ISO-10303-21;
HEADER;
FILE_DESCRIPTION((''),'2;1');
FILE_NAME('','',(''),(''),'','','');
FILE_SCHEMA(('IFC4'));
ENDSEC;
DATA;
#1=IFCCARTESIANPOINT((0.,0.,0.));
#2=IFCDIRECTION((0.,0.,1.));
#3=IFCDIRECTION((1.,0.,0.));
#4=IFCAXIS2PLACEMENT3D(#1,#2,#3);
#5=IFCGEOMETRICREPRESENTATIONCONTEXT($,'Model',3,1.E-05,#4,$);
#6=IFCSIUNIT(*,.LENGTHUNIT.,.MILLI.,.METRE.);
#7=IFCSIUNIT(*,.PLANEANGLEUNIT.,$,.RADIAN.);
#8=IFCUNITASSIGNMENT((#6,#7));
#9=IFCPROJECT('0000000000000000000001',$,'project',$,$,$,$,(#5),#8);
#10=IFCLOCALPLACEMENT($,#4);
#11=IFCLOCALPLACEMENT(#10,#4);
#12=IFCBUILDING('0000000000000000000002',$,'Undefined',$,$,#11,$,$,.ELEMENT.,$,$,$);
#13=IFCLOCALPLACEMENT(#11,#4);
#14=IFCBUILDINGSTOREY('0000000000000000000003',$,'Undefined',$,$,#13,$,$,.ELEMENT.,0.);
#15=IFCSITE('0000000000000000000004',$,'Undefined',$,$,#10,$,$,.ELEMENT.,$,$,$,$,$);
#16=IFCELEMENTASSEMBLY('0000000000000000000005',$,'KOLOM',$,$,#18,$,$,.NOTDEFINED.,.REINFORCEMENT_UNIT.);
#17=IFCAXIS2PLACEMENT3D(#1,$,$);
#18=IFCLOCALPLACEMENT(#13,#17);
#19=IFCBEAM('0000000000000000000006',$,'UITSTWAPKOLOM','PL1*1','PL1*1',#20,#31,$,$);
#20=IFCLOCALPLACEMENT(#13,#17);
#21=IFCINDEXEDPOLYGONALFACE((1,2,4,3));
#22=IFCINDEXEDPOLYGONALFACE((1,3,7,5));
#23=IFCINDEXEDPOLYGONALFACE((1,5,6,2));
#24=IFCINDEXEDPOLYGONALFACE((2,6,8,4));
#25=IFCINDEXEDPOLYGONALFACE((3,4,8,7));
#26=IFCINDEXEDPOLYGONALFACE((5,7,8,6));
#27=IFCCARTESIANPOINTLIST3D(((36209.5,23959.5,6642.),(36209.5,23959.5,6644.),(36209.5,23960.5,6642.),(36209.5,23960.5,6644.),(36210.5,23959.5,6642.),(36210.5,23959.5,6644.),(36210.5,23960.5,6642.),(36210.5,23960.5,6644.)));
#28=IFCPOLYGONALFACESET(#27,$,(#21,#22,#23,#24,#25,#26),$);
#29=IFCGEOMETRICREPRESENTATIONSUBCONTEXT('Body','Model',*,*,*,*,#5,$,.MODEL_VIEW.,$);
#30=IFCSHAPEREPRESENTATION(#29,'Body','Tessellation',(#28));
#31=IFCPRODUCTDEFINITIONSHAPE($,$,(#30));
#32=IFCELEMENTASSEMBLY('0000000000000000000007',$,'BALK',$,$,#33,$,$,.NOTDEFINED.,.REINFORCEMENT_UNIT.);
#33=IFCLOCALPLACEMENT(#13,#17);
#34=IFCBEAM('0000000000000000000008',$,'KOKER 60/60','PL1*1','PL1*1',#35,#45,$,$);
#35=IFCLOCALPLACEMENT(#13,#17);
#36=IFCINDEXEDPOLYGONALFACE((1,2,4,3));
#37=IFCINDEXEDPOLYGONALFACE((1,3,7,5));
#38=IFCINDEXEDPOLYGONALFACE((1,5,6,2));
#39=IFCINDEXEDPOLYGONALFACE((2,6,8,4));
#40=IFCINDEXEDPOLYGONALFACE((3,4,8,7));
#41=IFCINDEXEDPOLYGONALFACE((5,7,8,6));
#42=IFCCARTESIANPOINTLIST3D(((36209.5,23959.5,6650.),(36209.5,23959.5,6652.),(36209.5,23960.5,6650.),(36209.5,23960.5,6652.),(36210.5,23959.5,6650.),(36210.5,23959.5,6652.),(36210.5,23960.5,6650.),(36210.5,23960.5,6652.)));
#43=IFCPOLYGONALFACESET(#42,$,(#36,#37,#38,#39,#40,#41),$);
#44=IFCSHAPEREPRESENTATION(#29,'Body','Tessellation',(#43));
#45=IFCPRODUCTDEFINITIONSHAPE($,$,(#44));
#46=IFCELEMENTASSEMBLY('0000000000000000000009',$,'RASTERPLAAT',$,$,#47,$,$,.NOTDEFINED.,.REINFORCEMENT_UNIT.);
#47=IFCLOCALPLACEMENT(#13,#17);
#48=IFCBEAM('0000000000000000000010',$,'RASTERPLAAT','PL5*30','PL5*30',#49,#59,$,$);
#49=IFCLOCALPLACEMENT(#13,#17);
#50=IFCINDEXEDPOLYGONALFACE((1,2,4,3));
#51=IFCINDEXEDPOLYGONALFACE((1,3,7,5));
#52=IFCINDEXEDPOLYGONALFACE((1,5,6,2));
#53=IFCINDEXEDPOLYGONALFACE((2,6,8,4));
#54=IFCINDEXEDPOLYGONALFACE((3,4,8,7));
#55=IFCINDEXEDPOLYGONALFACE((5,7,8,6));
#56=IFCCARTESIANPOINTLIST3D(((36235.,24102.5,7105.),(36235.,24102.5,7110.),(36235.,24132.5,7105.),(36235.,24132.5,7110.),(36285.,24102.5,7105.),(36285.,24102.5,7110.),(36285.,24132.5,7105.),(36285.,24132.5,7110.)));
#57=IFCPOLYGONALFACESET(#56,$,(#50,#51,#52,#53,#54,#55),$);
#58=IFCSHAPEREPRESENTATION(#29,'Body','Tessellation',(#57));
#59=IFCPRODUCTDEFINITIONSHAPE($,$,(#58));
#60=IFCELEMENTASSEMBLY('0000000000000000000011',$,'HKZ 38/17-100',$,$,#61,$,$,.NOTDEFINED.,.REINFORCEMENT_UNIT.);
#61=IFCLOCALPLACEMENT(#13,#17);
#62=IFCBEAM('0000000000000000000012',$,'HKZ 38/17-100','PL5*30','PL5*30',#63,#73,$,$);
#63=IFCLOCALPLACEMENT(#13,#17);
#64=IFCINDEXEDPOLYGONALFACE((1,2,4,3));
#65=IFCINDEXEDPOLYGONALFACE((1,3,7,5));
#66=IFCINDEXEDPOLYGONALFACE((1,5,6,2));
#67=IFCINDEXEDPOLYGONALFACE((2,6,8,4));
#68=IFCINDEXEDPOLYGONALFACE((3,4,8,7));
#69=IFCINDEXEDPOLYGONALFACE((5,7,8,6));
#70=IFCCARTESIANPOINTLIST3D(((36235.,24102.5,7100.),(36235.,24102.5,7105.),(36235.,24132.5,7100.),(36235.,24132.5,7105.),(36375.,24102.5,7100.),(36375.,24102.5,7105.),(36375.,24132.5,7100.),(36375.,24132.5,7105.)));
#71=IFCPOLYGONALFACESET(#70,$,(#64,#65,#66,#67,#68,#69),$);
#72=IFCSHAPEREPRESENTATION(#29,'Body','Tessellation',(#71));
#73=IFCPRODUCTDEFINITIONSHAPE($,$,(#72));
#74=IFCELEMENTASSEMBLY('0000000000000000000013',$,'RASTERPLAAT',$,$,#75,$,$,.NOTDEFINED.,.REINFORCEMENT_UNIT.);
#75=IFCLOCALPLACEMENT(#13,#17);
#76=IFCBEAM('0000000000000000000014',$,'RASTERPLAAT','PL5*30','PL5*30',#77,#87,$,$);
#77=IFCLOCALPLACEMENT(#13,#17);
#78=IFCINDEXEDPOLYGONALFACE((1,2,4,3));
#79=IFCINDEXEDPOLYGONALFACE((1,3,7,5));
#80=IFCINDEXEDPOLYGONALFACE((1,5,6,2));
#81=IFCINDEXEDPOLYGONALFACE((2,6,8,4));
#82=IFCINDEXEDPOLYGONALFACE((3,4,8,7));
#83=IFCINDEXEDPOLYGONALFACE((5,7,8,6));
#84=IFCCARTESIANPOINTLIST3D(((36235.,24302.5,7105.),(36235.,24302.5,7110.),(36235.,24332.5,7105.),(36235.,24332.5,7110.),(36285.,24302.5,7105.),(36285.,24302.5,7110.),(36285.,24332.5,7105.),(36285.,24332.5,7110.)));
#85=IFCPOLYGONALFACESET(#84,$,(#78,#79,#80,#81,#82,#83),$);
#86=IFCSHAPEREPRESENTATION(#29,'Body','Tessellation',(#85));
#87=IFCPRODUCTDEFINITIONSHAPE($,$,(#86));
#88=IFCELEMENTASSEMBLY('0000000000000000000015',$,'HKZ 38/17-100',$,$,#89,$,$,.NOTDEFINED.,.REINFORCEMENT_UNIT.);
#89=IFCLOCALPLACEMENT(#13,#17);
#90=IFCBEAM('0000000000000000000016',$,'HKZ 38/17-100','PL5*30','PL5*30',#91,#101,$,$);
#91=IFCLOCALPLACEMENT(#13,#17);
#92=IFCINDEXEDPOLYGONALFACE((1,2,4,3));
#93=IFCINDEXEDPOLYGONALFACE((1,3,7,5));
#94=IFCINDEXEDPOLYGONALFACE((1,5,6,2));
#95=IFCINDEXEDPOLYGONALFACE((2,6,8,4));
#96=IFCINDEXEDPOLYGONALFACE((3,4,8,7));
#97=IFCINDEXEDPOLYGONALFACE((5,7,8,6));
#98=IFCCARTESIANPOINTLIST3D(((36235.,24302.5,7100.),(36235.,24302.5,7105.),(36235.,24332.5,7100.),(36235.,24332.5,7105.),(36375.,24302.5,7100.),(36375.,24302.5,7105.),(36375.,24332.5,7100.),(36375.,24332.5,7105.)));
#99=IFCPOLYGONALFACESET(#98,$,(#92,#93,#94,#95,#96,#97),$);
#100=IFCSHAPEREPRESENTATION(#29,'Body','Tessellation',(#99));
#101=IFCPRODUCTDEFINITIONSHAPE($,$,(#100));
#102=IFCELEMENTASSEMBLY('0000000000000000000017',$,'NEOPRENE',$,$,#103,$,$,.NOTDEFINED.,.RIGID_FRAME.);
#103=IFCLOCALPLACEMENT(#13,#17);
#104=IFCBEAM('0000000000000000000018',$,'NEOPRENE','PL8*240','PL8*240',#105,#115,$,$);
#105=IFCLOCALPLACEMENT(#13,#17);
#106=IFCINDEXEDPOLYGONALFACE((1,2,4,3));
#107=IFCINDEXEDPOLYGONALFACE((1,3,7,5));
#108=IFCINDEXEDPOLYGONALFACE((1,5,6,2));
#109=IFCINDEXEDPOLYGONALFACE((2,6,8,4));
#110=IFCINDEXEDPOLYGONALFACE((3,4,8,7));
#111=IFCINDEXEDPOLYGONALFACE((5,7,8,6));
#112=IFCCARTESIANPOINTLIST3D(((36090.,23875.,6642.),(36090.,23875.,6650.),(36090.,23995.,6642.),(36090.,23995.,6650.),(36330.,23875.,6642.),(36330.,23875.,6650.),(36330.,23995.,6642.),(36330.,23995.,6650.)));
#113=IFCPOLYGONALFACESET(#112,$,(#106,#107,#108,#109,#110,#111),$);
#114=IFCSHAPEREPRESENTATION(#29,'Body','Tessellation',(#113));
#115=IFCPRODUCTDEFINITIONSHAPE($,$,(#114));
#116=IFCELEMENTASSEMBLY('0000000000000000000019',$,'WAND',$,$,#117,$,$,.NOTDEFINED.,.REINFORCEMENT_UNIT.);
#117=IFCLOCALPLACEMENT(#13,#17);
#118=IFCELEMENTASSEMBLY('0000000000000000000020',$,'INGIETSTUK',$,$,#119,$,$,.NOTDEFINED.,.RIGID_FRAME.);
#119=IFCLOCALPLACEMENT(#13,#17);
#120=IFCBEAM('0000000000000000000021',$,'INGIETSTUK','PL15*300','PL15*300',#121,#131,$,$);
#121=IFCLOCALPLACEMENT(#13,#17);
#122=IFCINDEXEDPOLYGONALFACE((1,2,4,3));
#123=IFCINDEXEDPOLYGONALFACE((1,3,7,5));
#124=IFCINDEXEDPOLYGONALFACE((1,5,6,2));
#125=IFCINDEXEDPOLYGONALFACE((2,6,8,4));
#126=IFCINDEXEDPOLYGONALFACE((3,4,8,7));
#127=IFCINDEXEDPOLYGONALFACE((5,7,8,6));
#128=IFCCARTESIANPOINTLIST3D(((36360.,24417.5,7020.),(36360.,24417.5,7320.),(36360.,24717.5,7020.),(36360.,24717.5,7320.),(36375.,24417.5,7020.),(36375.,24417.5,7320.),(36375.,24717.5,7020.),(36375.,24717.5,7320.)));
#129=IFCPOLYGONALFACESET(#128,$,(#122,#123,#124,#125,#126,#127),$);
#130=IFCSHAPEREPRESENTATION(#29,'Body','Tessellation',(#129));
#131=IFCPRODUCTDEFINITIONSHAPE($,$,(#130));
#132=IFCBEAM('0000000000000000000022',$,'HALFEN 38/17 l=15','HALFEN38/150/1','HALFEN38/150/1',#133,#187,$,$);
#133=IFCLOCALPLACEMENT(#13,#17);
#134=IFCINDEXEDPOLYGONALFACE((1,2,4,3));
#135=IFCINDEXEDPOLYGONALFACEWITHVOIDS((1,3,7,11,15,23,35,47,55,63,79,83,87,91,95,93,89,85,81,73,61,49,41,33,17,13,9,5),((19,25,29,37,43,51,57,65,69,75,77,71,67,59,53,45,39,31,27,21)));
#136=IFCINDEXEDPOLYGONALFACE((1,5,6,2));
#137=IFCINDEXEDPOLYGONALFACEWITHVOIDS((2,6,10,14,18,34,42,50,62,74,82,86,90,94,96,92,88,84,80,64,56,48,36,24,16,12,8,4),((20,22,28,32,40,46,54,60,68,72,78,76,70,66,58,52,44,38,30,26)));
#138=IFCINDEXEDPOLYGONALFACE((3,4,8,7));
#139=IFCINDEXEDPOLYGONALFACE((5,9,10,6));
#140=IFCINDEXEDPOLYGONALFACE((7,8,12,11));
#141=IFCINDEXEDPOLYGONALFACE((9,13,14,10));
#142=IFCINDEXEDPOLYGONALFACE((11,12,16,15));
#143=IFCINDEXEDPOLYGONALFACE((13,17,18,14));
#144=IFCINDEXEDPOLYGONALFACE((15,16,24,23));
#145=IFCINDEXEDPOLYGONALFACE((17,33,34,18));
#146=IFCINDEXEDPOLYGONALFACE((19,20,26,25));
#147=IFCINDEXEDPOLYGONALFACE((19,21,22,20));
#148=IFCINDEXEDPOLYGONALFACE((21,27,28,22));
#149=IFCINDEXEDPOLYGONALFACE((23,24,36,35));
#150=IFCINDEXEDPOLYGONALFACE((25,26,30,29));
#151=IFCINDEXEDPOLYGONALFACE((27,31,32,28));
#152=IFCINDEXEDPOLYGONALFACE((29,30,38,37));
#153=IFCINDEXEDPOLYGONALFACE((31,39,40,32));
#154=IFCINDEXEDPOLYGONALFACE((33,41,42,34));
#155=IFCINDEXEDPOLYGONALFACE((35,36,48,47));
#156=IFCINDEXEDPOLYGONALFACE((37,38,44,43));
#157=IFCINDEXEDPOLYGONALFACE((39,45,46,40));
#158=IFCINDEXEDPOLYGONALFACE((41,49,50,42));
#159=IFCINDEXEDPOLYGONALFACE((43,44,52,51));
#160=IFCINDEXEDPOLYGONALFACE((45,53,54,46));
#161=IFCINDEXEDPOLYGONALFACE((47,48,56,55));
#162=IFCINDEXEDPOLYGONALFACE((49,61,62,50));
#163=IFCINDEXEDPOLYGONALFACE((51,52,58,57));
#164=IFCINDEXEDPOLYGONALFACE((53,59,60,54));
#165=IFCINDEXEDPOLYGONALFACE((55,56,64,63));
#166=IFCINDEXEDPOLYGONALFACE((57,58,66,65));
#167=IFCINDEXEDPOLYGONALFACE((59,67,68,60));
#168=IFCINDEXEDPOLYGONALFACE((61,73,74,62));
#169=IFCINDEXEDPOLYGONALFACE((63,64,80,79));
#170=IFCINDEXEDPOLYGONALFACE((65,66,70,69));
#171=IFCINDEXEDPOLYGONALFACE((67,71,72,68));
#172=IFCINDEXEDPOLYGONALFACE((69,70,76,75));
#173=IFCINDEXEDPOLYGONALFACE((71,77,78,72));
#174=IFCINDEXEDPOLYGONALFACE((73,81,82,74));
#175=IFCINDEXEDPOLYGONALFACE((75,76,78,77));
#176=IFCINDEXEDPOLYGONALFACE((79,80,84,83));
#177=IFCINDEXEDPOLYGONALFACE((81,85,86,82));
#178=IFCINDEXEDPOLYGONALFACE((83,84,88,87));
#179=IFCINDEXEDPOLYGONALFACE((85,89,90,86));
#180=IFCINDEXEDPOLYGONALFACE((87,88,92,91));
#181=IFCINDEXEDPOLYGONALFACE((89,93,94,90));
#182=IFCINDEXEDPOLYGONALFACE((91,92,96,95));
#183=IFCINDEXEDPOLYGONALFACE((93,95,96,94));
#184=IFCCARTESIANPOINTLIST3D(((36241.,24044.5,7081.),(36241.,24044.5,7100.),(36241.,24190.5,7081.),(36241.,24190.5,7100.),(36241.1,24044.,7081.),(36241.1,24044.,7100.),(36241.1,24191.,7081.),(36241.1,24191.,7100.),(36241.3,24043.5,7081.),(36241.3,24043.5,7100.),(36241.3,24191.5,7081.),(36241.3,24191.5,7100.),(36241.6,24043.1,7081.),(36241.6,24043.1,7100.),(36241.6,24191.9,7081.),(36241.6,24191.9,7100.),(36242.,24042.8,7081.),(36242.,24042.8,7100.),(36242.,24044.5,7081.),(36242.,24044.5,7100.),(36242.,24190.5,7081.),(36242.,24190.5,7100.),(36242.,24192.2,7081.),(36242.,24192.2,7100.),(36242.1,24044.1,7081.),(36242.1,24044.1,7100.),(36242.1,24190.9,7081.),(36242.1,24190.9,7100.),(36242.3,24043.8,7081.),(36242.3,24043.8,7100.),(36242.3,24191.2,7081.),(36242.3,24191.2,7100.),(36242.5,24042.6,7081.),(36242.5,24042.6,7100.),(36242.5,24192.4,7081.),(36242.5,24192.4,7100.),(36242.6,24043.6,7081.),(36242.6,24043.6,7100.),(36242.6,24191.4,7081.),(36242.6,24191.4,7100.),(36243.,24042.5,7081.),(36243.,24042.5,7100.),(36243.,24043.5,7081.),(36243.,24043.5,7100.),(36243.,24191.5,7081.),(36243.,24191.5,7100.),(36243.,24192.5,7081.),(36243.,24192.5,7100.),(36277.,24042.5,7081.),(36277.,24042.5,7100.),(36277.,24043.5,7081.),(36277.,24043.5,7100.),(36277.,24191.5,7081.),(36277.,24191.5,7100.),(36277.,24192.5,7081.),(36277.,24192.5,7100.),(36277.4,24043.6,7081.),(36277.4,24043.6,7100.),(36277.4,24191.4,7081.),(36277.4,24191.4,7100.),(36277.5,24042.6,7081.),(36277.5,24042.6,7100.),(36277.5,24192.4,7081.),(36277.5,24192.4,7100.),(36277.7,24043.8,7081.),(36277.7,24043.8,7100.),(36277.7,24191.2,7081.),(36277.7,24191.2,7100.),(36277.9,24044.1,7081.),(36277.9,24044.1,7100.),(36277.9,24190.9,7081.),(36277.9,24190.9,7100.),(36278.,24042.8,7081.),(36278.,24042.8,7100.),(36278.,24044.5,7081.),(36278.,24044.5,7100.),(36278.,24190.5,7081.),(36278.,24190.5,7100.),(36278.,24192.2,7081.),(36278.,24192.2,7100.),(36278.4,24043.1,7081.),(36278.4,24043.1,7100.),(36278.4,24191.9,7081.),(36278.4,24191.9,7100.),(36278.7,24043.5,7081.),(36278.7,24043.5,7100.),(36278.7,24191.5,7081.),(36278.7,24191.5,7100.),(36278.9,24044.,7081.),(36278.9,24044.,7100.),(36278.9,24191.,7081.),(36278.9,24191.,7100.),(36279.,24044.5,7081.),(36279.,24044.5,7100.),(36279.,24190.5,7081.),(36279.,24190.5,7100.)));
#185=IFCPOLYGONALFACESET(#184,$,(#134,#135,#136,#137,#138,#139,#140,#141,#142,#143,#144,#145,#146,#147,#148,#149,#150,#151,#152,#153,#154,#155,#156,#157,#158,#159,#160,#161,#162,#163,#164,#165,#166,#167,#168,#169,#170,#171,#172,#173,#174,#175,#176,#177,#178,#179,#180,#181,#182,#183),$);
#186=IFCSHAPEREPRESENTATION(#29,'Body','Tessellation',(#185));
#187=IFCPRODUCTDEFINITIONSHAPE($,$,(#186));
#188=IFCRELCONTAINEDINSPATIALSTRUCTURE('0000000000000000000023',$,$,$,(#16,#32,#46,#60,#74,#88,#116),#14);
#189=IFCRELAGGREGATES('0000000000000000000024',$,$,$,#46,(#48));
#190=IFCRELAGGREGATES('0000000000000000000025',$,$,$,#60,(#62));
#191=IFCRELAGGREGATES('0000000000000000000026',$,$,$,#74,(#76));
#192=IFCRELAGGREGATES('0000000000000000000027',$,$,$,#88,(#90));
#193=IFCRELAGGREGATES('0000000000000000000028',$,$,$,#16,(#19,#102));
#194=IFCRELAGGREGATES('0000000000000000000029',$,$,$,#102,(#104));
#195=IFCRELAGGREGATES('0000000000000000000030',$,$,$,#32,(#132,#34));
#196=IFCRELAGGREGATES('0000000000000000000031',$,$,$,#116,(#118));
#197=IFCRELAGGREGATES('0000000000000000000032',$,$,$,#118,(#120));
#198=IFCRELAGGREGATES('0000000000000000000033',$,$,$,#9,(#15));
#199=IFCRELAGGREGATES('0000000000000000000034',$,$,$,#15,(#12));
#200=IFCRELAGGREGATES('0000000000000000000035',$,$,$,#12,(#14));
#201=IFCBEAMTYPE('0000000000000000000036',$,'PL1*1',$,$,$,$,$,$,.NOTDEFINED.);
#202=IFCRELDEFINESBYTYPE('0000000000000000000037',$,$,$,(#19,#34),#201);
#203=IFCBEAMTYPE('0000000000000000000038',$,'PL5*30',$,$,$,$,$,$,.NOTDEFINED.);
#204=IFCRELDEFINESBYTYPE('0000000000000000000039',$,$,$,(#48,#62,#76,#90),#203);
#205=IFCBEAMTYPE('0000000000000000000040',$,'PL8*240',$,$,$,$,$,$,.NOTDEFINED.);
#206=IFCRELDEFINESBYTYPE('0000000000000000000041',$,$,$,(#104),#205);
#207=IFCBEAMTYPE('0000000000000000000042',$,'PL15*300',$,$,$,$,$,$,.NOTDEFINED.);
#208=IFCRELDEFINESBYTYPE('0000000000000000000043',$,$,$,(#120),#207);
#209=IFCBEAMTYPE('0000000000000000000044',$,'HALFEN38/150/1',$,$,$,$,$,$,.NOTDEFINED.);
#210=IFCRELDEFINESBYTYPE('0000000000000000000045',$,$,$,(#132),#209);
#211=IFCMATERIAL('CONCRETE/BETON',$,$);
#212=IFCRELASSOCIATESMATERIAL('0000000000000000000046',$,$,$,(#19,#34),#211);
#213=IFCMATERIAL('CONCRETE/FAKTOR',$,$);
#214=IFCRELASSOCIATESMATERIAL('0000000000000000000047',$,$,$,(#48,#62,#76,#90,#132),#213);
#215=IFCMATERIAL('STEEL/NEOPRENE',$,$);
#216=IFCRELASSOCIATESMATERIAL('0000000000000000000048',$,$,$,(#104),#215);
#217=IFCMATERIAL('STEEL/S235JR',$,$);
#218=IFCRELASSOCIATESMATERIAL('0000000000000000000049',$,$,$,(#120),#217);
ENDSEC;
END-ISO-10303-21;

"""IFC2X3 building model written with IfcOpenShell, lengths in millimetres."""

from ifc_helpers import new_model, si_unit, frame, frame_2d, origin_with_axes, place, context, subcontext, project, spatial, rectangle, hollow_rectangle, extrude, material, type_object, element, aggregate, save


model = new_model("IFC2X3")

# Units and contexts
model_context = context("Model", 3, precision=1e-05, world=origin_with_axes())
body_context = subcontext(model_context, "Body", "Model", "MODEL_VIEW")
ifc_project = project(units=[si_unit("LENGTHUNIT", "METRE", prefix="MILLI"), si_unit("PLANEANGLEUNIT", "RADIAN")], contexts=[model_context])

# Site, building, storey
site_placement = place(None, origin_with_axes())
site = spatial("IfcSite", under=ifc_project, at=site_placement, Name="Undefined", CompositionType="ELEMENT")
building_placement = place(site_placement, origin_with_axes())
building = spatial("IfcBuilding", under=site, at=building_placement, Name="Undefined", CompositionType="ELEMENT")
storey_placement = place(building_placement, origin_with_axes())
storey = spatial("IfcBuildingStorey", under=building, at=storey_placement, Name="Undefined", CompositionType="ELEMENT", Elevation=0.0)

# Element assemblies, beams
assembly_1_placement = place(storey_placement, origin_with_axes())
assembly_1 = element("IfcElementAssembly", 1, at=assembly_1_placement, inside=storey, Name="KOLOM", AssemblyPlace="NOTDEFINED", PredefinedType="REINFORCEMENT_UNIT")
ifc_material_1 = material(Name="CONCRETE/BETON")
beam_type_1 = type_object("IfcBeamType", Name="PL1*1", PredefinedType="NOTDEFINED")
beam_1_placement = place(assembly_1_placement, frame((36210.0, 23960.0, 6642.0), z_axis=(-1.0, 0.0, 0.0), x_axis=(0.0, 0.0, 1.0)))
beam_1 = element("IfcBeam", 2, at=beam_1_placement, type_object=beam_type_1, material=ifc_material_1, Name="UITSTWAPKOLOM", Description="PL1*1", ObjectType="PL1*1", context=body_context, shape_type="SweptSolid", body=[
    extrude(rectangle(XDim=1.0, YDim=1.0, at=frame_2d((0.0, 0.0), x_axis=(1.0, 0.0))), frame((2.0, 0.0, 0.0), z_axis=(-1.0, 0.0, 0.0), x_axis=(0.0, -1.0, 0.0)), (0.0, 0.0, 1.0), 2.0),
])
assembly_2_placement = place(storey_placement, origin_with_axes())
assembly_2 = element("IfcElementAssembly", 3, at=assembly_2_placement, inside=storey, Name="BALK", AssemblyPlace="NOTDEFINED", PredefinedType="REINFORCEMENT_UNIT")
beam_2_placement = place(assembly_2_placement, frame((36210.0, 23960.0, 6650.0), z_axis=(-1.0, 0.0, 0.0), x_axis=(0.0, 0.0, 1.0)))
beam_2 = element("IfcBeam", 4, at=beam_2_placement, type_object=beam_type_1, material=ifc_material_1, Name="KOKER 60/60", Description="PL1*1", ObjectType="PL1*1", context=body_context, shape_type="SweptSolid", body=[
    extrude(rectangle(XDim=1.0, YDim=1.0, at=frame_2d((0.0, 0.0), x_axis=(1.0, 0.0))), frame((2.0, 0.0, 0.0), z_axis=(-1.0, 0.0, 0.0), x_axis=(0.0, -1.0, 0.0)), (0.0, 0.0, 1.0), 2.0),
])
assembly_3_placement = place(storey_placement, origin_with_axes())
assembly_3 = element("IfcElementAssembly", 5, at=assembly_3_placement, inside=storey, Name="RASTERPLAAT", AssemblyPlace="NOTDEFINED", PredefinedType="REINFORCEMENT_UNIT")
ifc_material_2 = material(Name="CONCRETE/FAKTOR")
beam_type_2 = type_object("IfcBeamType", Name="PL5*30", PredefinedType="NOTDEFINED")
beam_3_placement = place(assembly_3_placement, frame((36235.0, 24117.5, 7107.5), z_axis=(0.0, -1.0, 0.0), x_axis=(1.0, 0.0, 0.0)))
beam_3 = element("IfcBeam", 6, at=beam_3_placement, type_object=beam_type_2, material=ifc_material_2, Name="RASTERPLAAT", Description="PL5*30", ObjectType="PL5*30", context=body_context, shape_type="SweptSolid", body=[
    extrude(rectangle(XDim=5.0, YDim=30.0, at=frame_2d((0.0, 0.0), x_axis=(1.0, 0.0))), frame((50.0, 0.0, 0.0), z_axis=(-1.0, 0.0, 0.0), x_axis=(0.0, -1.0, 0.0)), (0.0, 0.0, 1.0), 50.0),
])
aggregate(assembly_3, [beam_3])
assembly_4_placement = place(storey_placement, origin_with_axes())
assembly_4 = element("IfcElementAssembly", 7, at=assembly_4_placement, inside=storey, Name="HKZ 38/17-100", AssemblyPlace="NOTDEFINED", PredefinedType="REINFORCEMENT_UNIT")
beam_4_placement = place(assembly_4_placement, frame((36375.0, 24117.5, 7102.5), z_axis=(0.0, 1.0, 0.0), x_axis=(-1.0, 0.0, 0.0)))
beam_4 = element("IfcBeam", 8, at=beam_4_placement, type_object=beam_type_2, material=ifc_material_2, Name="HKZ 38/17-100", Description="PL5*30", ObjectType="PL5*30", context=body_context, shape_type="SweptSolid", body=[
    extrude(rectangle(XDim=5.0, YDim=30.0, at=frame_2d((0.0, 0.0), x_axis=(1.0, 0.0))), frame((140.0, 0.0, 0.0), z_axis=(-1.0, 0.0, 0.0), x_axis=(0.0, -1.0, 0.0)), (0.0, 0.0, 1.0), 140.0),
])
aggregate(assembly_4, [beam_4])
assembly_5_placement = place(storey_placement, origin_with_axes())
assembly_5 = element("IfcElementAssembly", 9, at=assembly_5_placement, inside=storey, Name="RASTERPLAAT", AssemblyPlace="NOTDEFINED", PredefinedType="REINFORCEMENT_UNIT")
beam_5_placement = place(assembly_5_placement, frame((36235.0, 24317.5, 7107.5), z_axis=(0.0, -1.0, 0.0), x_axis=(1.0, 0.0, 0.0)))
beam_5 = element("IfcBeam", 10, at=beam_5_placement, type_object=beam_type_2, material=ifc_material_2, Name="RASTERPLAAT", Description="PL5*30", ObjectType="PL5*30", context=body_context, shape_type="SweptSolid", body=[
    extrude(rectangle(XDim=5.0, YDim=30.0, at=frame_2d((0.0, 0.0), x_axis=(1.0, 0.0))), frame((50.0, 0.0, 0.0), z_axis=(-1.0, 0.0, 0.0), x_axis=(0.0, -1.0, 0.0)), (0.0, 0.0, 1.0), 50.0),
])
aggregate(assembly_5, [beam_5])
assembly_6_placement = place(storey_placement, origin_with_axes())
assembly_6 = element("IfcElementAssembly", 11, at=assembly_6_placement, inside=storey, Name="HKZ 38/17-100", AssemblyPlace="NOTDEFINED", PredefinedType="REINFORCEMENT_UNIT")
beam_6_placement = place(assembly_6_placement, frame((36375.0, 24317.5, 7102.5), z_axis=(0.0, 1.0, 0.0), x_axis=(-1.0, 0.0, 0.0)))
beam_6 = element("IfcBeam", 12, at=beam_6_placement, type_object=beam_type_2, material=ifc_material_2, Name="HKZ 38/17-100", Description="PL5*30", ObjectType="PL5*30", context=body_context, shape_type="SweptSolid", body=[
    extrude(rectangle(XDim=5.0, YDim=30.0, at=frame_2d((0.0, 0.0), x_axis=(1.0, 0.0))), frame((140.0, 0.0, 0.0), z_axis=(-1.0, 0.0, 0.0), x_axis=(0.0, -1.0, 0.0)), (0.0, 0.0, 1.0), 140.0),
])
aggregate(assembly_6, [beam_6])

# Element assembly
assembly_7_placement = place(assembly_1_placement, origin_with_axes())
assembly_7 = element("IfcElementAssembly", 13, at=assembly_7_placement, Name="NEOPRENE", AssemblyPlace="NOTDEFINED", PredefinedType="RIGID_FRAME")
aggregate(assembly_1, [beam_1, assembly_7])

# Beam
ifc_material_3 = material(Name="STEEL/NEOPRENE")
beam_type_3 = type_object("IfcBeamType", Name="PL8*240", PredefinedType="NOTDEFINED")
beam_7_placement = place(assembly_7_placement, frame((36210.0, 23875.0, 6646.0), z_axis=(-1.0, 0.0, 0.0), x_axis=(0.0, 1.0, 0.0)))
beam_7 = element("IfcBeam", 14, at=beam_7_placement, type_object=beam_type_3, material=ifc_material_3, Name="NEOPRENE", Description="PL8*240", ObjectType="PL8*240", context=body_context, shape_type="SweptSolid", body=[
    extrude(rectangle(XDim=8.0, YDim=240.0, at=frame_2d((0.0, 0.0), x_axis=(1.0, 0.0))), frame((120.0, 0.0, 0.0), z_axis=(-1.0, 0.0, 0.0), x_axis=(0.0, -1.0, 0.0)), (0.0, 0.0, 1.0), 120.0),
])
aggregate(assembly_7, [beam_7])

# Element assemblies, beam
assembly_8_placement = place(storey_placement, origin_with_axes())
assembly_8 = element("IfcElementAssembly", 15, at=assembly_8_placement, inside=storey, Name="WAND", AssemblyPlace="NOTDEFINED", PredefinedType="REINFORCEMENT_UNIT")
assembly_9_placement = place(assembly_8_placement, origin_with_axes())
assembly_9 = element("IfcElementAssembly", 16, at=assembly_9_placement, Name="INGIETSTUK", AssemblyPlace="NOTDEFINED", PredefinedType="RIGID_FRAME")
ifc_material_4 = material(Name="STEEL/S235JR")
beam_type_4 = type_object("IfcBeamType", Name="PL15*300", PredefinedType="NOTDEFINED")
beam_8_placement = place(assembly_9_placement, frame((36367.5, 24417.5, 7170.0), z_axis=(0.0, 0.0, 1.0), x_axis=(0.0, 1.0, 0.0)))
beam_8 = element("IfcBeam", 17, at=beam_8_placement, type_object=beam_type_4, material=ifc_material_4, Name="INGIETSTUK", Description="PL15*300", ObjectType="PL15*300", context=body_context, shape_type="SweptSolid", body=[
    extrude(rectangle(XDim=15.0, YDim=300.0, at=frame_2d((0.0, 0.0), x_axis=(1.0, 0.0))), frame((300.0, 0.0, 0.0), z_axis=(-1.0, 0.0, 0.0), x_axis=(0.0, -1.0, 0.0)), (0.0, 0.0, 1.0), 300.0),
])

# Beam
beam_type_5 = type_object("IfcBeamType", Name="HALFEN38/150/1", PredefinedType="NOTDEFINED")
beam_9_placement = place(assembly_2_placement, frame((36260.0, 24117.5, 7100.0), z_axis=(1.0, 0.0, 0.0), x_axis=(0.0, 0.0, -1.0)))
beam_9 = element("IfcBeam", 18, at=beam_9_placement, type_object=beam_type_5, material=ifc_material_2, Name="HALFEN 38/17 l=15", Description="HALFEN38/150/1", ObjectType="HALFEN38/150/1", context=body_context, shape_type="SweptSolid", body=[
    extrude(hollow_rectangle(XDim=150.0, YDim=38.0, WallThickness=1.0, InnerFilletRadius=1.0, OuterFilletRadius=2.0, at=frame_2d((0.0, 0.0), x_axis=(1.0, 0.0))), frame((19.0, 0.0, 0.0), z_axis=(-1.0, 0.0, 0.0), x_axis=(0.0, -1.0, 0.0)), (0.0, 0.0, 1.0), 19.0),
])

aggregate(assembly_2, [beam_9, beam_2])
aggregate(assembly_8, [assembly_9])

aggregate(assembly_9, [beam_8])

save(model, "model.ifc")
